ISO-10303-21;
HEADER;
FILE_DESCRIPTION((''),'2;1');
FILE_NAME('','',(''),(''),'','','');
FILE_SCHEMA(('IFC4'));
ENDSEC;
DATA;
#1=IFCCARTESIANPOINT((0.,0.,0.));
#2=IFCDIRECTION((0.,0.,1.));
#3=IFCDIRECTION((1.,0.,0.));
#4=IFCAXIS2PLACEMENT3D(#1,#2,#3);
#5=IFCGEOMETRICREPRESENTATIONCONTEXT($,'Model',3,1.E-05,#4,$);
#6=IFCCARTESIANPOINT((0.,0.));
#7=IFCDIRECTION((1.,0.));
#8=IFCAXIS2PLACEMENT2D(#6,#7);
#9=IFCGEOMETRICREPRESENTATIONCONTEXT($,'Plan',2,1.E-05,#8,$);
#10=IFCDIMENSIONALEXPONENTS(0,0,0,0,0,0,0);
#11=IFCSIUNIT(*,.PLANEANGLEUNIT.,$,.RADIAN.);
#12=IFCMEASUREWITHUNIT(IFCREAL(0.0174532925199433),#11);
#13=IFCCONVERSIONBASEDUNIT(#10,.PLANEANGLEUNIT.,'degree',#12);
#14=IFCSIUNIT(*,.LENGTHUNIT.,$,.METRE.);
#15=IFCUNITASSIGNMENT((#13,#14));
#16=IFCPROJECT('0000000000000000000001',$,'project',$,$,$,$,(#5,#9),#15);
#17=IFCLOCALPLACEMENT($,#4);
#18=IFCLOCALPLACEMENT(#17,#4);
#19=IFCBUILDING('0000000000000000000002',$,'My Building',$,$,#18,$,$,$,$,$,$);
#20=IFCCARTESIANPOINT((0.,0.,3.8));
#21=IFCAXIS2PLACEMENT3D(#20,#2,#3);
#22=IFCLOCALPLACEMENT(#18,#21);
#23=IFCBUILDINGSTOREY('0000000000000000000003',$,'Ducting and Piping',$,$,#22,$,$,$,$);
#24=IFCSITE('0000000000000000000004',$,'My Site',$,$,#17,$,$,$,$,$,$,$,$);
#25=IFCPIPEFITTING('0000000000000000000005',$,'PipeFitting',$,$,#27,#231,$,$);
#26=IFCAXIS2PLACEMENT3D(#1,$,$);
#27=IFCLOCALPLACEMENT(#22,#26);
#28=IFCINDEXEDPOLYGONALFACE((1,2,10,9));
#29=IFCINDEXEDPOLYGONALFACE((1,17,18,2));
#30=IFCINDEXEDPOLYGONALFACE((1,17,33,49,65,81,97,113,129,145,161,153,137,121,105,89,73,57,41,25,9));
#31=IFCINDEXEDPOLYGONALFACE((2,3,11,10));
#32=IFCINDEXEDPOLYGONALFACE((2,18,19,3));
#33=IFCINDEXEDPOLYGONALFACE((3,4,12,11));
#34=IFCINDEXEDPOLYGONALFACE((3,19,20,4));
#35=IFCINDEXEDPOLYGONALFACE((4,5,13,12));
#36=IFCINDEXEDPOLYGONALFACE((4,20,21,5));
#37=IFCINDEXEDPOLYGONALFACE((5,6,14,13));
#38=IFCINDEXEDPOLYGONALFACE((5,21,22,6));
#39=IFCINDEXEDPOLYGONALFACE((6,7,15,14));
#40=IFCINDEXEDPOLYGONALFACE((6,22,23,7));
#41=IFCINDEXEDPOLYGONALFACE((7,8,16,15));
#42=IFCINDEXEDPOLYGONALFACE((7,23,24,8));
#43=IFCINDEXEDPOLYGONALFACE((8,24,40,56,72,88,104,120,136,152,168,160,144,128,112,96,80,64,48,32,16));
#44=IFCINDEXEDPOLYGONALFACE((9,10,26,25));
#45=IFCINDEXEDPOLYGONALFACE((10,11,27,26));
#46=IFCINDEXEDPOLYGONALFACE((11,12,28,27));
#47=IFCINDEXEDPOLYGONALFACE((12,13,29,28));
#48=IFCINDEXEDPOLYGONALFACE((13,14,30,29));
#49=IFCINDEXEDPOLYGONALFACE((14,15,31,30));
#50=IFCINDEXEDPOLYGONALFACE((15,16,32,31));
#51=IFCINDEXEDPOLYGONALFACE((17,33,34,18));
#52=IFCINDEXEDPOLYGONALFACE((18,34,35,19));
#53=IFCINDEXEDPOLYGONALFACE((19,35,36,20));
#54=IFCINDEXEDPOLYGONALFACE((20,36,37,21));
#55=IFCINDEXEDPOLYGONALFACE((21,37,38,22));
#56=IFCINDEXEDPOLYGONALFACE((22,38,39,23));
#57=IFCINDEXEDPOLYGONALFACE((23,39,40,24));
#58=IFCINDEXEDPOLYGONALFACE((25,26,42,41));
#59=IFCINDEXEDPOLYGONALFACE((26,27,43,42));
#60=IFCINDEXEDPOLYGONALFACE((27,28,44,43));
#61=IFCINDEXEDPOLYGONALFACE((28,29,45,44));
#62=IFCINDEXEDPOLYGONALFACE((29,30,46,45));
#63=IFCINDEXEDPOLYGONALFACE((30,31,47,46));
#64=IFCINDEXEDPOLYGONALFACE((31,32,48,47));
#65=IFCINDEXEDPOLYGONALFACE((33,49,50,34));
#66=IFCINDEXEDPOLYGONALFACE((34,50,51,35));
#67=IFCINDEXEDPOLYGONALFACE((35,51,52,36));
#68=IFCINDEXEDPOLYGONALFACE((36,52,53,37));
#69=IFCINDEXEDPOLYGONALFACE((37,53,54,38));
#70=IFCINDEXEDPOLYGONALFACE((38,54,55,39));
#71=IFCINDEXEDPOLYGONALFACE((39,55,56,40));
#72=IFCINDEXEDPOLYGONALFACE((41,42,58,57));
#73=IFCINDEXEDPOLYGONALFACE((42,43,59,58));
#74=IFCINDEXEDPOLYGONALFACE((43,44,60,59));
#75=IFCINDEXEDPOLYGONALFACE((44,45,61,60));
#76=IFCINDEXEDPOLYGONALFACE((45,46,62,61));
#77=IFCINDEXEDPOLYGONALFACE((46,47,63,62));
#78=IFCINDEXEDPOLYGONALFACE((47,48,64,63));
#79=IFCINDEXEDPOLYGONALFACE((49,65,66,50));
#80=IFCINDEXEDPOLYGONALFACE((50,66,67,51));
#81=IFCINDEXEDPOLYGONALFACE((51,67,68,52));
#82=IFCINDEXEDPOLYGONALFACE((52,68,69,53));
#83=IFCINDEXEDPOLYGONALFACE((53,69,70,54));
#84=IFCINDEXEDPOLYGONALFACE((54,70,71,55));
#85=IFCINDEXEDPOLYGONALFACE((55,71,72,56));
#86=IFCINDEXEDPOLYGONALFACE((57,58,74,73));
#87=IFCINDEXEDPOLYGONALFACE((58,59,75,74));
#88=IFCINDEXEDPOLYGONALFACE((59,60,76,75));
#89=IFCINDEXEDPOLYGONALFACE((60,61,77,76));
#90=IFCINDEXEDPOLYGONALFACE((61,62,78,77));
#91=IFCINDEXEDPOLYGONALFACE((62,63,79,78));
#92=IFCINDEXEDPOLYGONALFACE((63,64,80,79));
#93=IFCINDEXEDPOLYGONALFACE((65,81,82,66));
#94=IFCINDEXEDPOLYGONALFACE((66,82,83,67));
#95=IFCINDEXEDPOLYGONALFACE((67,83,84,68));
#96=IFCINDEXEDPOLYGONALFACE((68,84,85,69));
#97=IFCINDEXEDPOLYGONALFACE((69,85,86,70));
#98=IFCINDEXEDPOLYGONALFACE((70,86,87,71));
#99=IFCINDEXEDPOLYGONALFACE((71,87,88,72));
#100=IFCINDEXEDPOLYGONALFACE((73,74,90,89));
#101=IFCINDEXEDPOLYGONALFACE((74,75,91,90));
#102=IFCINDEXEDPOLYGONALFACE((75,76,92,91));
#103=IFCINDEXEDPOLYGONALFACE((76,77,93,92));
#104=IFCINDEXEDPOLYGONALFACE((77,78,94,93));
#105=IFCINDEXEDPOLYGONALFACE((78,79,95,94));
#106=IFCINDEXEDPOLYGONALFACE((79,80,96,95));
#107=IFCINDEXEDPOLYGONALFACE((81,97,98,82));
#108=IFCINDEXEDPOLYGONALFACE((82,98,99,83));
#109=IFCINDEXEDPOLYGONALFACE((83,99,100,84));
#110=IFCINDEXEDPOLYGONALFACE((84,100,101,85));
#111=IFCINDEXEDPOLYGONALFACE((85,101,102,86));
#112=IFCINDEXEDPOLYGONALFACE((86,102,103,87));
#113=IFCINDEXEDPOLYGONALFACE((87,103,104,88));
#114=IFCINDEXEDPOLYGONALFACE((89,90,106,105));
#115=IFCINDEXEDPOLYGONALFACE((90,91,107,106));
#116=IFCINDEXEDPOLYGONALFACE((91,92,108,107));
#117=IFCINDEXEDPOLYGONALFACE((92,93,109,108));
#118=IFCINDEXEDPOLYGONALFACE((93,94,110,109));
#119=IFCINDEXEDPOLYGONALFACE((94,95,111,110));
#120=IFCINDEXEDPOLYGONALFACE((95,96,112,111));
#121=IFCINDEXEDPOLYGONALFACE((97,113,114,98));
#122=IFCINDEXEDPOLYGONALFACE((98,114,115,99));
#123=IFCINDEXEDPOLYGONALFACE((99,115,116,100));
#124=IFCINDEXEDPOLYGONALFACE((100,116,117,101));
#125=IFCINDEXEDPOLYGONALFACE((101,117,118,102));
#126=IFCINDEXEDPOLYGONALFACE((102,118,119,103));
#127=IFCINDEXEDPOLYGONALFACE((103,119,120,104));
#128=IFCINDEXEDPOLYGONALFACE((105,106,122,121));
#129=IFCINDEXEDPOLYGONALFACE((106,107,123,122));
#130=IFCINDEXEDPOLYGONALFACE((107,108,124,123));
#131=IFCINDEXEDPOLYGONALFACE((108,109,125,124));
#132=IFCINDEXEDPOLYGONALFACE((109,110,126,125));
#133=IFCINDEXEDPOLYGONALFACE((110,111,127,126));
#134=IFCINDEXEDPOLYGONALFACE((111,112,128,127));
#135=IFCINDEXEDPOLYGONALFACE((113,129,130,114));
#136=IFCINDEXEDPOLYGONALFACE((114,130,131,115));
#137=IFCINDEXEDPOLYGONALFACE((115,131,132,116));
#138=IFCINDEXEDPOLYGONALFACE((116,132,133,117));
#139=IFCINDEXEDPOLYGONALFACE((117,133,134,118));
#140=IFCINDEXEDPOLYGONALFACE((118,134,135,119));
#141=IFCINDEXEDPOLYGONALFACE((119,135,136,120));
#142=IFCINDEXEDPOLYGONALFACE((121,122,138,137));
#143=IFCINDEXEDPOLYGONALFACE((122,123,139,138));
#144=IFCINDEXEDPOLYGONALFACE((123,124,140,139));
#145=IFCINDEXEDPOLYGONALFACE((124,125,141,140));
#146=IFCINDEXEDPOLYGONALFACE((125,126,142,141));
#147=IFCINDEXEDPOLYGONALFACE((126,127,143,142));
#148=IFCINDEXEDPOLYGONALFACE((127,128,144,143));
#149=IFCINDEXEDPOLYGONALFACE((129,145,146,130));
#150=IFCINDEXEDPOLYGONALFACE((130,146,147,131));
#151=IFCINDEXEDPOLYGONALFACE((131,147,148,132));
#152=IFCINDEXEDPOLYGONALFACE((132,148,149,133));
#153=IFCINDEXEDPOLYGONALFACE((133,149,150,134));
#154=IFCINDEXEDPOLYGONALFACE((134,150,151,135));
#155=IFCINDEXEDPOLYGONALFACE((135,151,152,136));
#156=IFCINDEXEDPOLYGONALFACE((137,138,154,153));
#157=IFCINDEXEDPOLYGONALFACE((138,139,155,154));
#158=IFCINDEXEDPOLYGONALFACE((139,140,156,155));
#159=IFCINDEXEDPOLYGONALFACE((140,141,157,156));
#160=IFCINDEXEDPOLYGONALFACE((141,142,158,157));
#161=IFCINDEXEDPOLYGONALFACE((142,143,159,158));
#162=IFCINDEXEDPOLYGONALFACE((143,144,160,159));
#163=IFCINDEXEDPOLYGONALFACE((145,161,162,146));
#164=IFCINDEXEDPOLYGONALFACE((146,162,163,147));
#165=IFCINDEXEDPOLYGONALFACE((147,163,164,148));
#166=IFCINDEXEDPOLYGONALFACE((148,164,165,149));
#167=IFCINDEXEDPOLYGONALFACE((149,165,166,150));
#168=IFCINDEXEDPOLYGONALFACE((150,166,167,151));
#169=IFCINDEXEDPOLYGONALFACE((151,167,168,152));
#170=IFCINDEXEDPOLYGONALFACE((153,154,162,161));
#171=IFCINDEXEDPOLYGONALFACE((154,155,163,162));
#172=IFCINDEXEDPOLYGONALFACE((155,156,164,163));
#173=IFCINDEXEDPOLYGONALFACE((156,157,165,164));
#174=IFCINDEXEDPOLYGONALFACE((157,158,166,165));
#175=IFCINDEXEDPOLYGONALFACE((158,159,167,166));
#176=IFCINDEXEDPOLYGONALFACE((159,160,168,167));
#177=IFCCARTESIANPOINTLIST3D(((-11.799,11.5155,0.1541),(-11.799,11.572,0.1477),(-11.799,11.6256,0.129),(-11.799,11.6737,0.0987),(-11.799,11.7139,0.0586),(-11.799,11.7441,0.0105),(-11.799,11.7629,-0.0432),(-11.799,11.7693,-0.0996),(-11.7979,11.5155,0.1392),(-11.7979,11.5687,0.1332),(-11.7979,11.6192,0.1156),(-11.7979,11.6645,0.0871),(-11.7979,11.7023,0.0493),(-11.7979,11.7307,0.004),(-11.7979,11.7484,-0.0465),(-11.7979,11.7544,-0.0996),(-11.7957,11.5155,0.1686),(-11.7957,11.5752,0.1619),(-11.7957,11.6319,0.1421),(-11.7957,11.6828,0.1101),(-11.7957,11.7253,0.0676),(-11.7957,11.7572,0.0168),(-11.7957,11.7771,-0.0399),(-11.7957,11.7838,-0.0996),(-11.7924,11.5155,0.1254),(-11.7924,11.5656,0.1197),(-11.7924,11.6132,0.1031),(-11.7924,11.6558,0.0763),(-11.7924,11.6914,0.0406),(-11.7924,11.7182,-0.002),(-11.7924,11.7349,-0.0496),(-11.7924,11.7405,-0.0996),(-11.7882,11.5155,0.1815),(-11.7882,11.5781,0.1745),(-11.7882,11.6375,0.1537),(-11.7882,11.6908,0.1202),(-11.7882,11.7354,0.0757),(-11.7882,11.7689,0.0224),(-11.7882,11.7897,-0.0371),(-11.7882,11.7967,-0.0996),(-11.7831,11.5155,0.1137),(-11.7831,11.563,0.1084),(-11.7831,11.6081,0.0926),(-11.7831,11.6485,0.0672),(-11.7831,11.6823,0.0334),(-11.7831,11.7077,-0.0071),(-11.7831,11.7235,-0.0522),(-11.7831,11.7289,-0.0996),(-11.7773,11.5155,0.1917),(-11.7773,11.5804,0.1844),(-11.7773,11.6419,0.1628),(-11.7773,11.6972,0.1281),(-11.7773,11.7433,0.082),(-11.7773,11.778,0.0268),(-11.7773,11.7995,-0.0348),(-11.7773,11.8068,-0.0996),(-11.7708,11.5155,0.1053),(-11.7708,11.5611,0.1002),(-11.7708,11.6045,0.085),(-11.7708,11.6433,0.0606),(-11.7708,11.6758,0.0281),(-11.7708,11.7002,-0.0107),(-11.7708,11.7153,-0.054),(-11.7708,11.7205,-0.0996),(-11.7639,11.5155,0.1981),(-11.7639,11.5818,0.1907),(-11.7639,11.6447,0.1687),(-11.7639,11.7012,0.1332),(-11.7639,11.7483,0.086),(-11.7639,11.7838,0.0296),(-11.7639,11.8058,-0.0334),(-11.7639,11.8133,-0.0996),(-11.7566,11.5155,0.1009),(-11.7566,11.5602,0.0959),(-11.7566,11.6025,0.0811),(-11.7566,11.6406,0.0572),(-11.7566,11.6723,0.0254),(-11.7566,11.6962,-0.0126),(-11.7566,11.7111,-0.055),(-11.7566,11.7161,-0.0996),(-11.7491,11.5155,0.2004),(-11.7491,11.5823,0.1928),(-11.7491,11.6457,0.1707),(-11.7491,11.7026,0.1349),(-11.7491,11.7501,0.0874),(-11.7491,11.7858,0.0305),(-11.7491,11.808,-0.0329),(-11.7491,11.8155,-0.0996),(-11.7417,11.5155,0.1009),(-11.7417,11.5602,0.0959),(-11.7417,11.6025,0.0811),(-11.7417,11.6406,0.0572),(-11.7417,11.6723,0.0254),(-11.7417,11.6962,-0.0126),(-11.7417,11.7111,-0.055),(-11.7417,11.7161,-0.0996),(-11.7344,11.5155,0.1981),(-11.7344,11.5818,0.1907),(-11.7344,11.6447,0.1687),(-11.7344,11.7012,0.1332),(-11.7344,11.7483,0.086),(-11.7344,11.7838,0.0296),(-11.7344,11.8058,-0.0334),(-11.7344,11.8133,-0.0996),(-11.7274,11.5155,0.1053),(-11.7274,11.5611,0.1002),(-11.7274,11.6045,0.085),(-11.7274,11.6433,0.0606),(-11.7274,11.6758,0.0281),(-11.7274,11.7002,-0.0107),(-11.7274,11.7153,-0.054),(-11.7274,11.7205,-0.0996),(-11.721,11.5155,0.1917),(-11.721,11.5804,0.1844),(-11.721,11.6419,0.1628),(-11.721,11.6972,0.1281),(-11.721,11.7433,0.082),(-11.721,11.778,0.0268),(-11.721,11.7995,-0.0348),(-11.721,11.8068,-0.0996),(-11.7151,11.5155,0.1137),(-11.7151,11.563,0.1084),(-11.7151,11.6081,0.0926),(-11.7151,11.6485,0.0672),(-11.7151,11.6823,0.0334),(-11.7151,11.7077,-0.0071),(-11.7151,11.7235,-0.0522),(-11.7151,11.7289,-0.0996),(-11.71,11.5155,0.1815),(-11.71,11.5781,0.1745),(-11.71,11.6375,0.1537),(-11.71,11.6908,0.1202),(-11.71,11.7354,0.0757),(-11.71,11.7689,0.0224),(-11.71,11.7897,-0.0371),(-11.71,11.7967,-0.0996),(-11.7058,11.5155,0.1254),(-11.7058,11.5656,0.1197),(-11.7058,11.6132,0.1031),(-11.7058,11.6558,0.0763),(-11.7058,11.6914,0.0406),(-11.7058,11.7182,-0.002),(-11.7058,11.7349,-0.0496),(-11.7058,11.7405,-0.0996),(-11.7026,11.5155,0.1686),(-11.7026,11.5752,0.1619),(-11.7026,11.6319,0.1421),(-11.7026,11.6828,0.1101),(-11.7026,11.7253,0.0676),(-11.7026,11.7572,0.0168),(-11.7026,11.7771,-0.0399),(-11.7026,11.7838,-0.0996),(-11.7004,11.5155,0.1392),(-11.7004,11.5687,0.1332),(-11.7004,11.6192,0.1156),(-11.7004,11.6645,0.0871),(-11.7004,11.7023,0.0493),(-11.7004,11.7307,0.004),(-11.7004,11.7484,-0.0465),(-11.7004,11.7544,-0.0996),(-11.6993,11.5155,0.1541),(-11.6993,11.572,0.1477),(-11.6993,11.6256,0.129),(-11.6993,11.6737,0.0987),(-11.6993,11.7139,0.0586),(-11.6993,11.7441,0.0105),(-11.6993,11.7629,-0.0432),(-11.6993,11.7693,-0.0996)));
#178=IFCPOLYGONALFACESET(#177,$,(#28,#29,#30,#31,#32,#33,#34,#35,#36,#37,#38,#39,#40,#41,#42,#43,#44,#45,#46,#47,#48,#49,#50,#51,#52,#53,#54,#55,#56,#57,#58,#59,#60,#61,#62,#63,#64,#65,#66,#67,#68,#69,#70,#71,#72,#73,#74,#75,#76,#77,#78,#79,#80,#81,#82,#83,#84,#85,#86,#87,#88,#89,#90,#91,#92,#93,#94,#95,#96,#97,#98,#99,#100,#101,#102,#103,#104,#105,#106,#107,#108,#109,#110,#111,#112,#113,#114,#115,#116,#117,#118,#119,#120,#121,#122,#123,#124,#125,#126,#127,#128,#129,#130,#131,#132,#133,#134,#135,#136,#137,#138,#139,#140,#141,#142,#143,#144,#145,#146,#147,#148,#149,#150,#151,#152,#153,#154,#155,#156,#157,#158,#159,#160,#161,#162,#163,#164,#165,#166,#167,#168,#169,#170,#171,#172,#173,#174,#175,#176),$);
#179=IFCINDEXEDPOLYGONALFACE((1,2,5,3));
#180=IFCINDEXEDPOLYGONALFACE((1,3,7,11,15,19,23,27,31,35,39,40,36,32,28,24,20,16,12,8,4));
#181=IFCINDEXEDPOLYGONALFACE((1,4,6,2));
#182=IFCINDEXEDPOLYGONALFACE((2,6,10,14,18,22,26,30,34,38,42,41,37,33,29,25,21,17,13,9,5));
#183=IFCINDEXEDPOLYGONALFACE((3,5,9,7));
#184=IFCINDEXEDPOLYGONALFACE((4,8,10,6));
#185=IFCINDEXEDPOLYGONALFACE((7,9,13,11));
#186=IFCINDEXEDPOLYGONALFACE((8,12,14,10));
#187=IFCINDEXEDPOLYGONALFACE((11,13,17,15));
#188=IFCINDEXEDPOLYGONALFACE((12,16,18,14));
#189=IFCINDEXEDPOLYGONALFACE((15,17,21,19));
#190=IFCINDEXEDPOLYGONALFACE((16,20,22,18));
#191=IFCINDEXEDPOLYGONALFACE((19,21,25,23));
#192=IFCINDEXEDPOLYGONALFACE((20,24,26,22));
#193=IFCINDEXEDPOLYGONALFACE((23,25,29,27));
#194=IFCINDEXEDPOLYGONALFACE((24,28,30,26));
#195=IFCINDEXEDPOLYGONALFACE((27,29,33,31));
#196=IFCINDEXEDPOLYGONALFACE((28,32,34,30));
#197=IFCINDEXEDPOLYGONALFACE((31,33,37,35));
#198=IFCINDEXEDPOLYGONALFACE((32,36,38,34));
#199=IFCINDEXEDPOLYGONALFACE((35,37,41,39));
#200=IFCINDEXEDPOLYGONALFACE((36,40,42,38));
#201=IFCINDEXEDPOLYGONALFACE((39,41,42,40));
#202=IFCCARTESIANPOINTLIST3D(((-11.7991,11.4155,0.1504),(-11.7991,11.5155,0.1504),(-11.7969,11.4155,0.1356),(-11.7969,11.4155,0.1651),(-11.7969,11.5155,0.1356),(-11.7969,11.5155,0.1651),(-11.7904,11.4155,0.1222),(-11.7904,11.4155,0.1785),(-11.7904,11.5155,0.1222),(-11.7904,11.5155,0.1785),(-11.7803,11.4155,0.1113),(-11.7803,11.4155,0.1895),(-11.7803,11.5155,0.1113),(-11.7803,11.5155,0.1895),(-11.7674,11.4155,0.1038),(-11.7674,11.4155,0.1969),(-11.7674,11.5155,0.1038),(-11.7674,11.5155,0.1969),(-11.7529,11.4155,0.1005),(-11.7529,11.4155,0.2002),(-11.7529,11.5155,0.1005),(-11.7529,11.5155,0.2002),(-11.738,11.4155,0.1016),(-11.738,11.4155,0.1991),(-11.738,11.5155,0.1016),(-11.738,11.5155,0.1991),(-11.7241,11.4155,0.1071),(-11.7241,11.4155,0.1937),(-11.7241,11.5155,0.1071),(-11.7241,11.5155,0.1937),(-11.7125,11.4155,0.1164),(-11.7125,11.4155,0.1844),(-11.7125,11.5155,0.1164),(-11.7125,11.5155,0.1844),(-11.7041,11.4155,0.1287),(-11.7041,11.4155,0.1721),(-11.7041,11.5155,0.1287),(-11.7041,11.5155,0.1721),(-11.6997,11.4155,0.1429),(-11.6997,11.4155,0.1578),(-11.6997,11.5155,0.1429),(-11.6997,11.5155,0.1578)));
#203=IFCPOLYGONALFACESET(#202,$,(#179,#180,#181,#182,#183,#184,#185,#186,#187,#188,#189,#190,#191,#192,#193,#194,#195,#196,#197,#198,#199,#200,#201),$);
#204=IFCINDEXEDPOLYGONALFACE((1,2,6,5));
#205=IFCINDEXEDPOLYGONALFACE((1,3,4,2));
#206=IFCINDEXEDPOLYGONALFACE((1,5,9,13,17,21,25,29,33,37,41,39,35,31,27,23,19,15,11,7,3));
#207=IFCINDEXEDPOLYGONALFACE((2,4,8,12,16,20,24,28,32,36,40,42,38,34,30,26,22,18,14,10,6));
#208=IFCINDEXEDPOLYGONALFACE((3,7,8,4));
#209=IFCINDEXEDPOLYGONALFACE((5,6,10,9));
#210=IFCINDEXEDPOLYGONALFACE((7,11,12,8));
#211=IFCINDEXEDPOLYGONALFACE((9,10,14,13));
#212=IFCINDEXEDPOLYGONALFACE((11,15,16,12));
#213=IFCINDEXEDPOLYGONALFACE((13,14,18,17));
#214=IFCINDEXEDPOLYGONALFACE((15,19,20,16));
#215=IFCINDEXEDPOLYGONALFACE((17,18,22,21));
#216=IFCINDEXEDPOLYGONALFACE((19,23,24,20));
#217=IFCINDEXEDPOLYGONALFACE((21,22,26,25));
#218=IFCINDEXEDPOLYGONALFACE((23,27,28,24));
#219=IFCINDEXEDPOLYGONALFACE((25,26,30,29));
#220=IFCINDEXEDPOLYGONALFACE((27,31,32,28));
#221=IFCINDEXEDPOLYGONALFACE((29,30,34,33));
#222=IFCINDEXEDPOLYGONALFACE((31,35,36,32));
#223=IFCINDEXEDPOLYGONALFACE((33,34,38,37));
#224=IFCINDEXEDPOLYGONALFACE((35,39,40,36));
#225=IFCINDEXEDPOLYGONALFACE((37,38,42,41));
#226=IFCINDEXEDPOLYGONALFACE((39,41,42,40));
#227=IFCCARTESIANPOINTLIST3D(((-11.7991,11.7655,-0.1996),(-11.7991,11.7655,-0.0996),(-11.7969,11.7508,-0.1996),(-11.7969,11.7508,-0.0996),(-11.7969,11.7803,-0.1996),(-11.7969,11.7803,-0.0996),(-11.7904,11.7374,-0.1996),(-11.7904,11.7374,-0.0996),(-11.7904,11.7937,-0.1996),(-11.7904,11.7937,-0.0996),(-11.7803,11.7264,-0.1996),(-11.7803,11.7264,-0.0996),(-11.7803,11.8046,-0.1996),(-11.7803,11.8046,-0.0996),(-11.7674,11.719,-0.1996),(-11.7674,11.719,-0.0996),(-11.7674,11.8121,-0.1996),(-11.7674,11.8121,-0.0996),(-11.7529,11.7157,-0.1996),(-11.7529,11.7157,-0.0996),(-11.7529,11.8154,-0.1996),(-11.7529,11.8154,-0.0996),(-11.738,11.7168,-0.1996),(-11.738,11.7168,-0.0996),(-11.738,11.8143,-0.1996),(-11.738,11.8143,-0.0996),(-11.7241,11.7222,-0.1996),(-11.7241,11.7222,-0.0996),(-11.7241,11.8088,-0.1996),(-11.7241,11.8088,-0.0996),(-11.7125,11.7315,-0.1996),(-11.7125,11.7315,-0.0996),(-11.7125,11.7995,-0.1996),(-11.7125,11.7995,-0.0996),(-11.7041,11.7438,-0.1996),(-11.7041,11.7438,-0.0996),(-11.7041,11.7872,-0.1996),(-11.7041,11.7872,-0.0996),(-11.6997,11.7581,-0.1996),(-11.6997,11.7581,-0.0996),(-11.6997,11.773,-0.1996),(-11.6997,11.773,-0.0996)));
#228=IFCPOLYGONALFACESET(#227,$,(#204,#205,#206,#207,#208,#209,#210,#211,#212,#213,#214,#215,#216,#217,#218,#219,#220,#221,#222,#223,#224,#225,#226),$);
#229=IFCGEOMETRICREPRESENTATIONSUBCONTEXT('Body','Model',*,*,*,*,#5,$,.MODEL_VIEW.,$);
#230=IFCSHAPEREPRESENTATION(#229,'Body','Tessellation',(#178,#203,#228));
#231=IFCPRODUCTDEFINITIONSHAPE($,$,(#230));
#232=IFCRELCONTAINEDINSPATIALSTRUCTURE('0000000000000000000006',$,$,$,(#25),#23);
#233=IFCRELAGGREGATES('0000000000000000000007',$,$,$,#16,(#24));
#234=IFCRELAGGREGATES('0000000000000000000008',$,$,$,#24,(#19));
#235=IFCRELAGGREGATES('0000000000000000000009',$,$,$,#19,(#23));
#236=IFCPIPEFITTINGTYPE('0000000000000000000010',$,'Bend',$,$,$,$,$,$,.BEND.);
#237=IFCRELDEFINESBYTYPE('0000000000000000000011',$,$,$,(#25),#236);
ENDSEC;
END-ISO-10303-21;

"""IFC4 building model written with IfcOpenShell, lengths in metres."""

from ifc_helpers import new_model, entity, si_unit, converted_unit, frame, origin_with_axes, origin_2d_with_axis, place, context, subcontext, project, spatial, circle, extrude, source, transform, mapped, type_object, type_shapes, element, save


model = new_model("IFC4")

# Units and contexts
model_context = context("Model", 3, precision=1e-05, world=origin_with_axes())
plan_context = context("Plan", 2, precision=1e-05, world=origin_2d_with_axis())
body_context = subcontext(model_context, "Body", "Model", "MODEL_VIEW")
ifc_project = project(units=[converted_unit("PLANEANGLEUNIT", "degree", entity("IfcReal", 0.0174532925199433), si_unit("PLANEANGLEUNIT", "RADIAN"), dimensions=[0, 0, 0, 0, 0, 0, 0]), si_unit("LENGTHUNIT", "METRE")], contexts=[model_context, plan_context])

# Site, building, storey
site_placement = place(None, origin_with_axes())
site = spatial("IfcSite", under=ifc_project, at=site_placement, Name="My Site")
building_placement = place(site_placement, origin_with_axes())
building = spatial("IfcBuilding", under=site, at=building_placement, Name="My Building")
storey_placement = place(building_placement, frame((0.0, 0.0, 3.8), z_axis=(0.0, 0.0, 1.0), x_axis=(1.0, 0.0, 0.0)))
storey = spatial("IfcBuildingStorey", under=building, at=storey_placement, Name="Ducting and Piping")

# Pipe fitting
pipe_fitting_type = type_object("IfcPipeFittingType", Name="Bend", PredefinedType="BEND")
shared_shape = source(origin_with_axes(), body_context, "Body", "SolidModel", [
    entity("IfcSweptDiskSolid", entity("IfcIndexedPolyCurve", entity("IfcCartesianPointList3D", [[0.0, 0.0, 0.1], [0.0, -0.0732, 0.2768], [0.0, -0.25, 0.35]]), [entity("IfcArcIndex", [1, 2, 3])]), 0.05),
    extrude(circle(Radius=0.05), origin_with_axes(), (0.0, 0.0, 1.0), 0.1),
    extrude(circle(Radius=0.05), frame((0.0, -0.25, 0.35), z_axis=(0.0, -1.0, 0.0), x_axis=(1.0, 0.0, 0.0)), (0.0, 0.0, 1.0), 0.1),
])
type_shapes(pipe_fitting_type, [shared_shape])
for number, where, z_axis, x_axis, name in (
    (1, (-11.7491, 11.4155, 0.1504), (0.0, 1.0, 0.0), (-1.0, 0.0, 0.0), "PipeFitting"),
):
    element("IfcPipeFitting", number, at=place(storey_placement, frame(where, z_axis=z_axis, x_axis=x_axis)), inside=storey, type_object=pipe_fitting_type, Name=name, context=body_context, shape_type="MappedRepresentation", body=[
        mapped(shared_shape, transform((0.0, 0.0, 0.0), x_axis=(1.0, 0.0, 0.0), y_axis=(0.0, 1.0, 0.0), z_axis=(0.0, 0.0, 1.0), scale=1.0)),
    ])

save(model, "model.ifc")
